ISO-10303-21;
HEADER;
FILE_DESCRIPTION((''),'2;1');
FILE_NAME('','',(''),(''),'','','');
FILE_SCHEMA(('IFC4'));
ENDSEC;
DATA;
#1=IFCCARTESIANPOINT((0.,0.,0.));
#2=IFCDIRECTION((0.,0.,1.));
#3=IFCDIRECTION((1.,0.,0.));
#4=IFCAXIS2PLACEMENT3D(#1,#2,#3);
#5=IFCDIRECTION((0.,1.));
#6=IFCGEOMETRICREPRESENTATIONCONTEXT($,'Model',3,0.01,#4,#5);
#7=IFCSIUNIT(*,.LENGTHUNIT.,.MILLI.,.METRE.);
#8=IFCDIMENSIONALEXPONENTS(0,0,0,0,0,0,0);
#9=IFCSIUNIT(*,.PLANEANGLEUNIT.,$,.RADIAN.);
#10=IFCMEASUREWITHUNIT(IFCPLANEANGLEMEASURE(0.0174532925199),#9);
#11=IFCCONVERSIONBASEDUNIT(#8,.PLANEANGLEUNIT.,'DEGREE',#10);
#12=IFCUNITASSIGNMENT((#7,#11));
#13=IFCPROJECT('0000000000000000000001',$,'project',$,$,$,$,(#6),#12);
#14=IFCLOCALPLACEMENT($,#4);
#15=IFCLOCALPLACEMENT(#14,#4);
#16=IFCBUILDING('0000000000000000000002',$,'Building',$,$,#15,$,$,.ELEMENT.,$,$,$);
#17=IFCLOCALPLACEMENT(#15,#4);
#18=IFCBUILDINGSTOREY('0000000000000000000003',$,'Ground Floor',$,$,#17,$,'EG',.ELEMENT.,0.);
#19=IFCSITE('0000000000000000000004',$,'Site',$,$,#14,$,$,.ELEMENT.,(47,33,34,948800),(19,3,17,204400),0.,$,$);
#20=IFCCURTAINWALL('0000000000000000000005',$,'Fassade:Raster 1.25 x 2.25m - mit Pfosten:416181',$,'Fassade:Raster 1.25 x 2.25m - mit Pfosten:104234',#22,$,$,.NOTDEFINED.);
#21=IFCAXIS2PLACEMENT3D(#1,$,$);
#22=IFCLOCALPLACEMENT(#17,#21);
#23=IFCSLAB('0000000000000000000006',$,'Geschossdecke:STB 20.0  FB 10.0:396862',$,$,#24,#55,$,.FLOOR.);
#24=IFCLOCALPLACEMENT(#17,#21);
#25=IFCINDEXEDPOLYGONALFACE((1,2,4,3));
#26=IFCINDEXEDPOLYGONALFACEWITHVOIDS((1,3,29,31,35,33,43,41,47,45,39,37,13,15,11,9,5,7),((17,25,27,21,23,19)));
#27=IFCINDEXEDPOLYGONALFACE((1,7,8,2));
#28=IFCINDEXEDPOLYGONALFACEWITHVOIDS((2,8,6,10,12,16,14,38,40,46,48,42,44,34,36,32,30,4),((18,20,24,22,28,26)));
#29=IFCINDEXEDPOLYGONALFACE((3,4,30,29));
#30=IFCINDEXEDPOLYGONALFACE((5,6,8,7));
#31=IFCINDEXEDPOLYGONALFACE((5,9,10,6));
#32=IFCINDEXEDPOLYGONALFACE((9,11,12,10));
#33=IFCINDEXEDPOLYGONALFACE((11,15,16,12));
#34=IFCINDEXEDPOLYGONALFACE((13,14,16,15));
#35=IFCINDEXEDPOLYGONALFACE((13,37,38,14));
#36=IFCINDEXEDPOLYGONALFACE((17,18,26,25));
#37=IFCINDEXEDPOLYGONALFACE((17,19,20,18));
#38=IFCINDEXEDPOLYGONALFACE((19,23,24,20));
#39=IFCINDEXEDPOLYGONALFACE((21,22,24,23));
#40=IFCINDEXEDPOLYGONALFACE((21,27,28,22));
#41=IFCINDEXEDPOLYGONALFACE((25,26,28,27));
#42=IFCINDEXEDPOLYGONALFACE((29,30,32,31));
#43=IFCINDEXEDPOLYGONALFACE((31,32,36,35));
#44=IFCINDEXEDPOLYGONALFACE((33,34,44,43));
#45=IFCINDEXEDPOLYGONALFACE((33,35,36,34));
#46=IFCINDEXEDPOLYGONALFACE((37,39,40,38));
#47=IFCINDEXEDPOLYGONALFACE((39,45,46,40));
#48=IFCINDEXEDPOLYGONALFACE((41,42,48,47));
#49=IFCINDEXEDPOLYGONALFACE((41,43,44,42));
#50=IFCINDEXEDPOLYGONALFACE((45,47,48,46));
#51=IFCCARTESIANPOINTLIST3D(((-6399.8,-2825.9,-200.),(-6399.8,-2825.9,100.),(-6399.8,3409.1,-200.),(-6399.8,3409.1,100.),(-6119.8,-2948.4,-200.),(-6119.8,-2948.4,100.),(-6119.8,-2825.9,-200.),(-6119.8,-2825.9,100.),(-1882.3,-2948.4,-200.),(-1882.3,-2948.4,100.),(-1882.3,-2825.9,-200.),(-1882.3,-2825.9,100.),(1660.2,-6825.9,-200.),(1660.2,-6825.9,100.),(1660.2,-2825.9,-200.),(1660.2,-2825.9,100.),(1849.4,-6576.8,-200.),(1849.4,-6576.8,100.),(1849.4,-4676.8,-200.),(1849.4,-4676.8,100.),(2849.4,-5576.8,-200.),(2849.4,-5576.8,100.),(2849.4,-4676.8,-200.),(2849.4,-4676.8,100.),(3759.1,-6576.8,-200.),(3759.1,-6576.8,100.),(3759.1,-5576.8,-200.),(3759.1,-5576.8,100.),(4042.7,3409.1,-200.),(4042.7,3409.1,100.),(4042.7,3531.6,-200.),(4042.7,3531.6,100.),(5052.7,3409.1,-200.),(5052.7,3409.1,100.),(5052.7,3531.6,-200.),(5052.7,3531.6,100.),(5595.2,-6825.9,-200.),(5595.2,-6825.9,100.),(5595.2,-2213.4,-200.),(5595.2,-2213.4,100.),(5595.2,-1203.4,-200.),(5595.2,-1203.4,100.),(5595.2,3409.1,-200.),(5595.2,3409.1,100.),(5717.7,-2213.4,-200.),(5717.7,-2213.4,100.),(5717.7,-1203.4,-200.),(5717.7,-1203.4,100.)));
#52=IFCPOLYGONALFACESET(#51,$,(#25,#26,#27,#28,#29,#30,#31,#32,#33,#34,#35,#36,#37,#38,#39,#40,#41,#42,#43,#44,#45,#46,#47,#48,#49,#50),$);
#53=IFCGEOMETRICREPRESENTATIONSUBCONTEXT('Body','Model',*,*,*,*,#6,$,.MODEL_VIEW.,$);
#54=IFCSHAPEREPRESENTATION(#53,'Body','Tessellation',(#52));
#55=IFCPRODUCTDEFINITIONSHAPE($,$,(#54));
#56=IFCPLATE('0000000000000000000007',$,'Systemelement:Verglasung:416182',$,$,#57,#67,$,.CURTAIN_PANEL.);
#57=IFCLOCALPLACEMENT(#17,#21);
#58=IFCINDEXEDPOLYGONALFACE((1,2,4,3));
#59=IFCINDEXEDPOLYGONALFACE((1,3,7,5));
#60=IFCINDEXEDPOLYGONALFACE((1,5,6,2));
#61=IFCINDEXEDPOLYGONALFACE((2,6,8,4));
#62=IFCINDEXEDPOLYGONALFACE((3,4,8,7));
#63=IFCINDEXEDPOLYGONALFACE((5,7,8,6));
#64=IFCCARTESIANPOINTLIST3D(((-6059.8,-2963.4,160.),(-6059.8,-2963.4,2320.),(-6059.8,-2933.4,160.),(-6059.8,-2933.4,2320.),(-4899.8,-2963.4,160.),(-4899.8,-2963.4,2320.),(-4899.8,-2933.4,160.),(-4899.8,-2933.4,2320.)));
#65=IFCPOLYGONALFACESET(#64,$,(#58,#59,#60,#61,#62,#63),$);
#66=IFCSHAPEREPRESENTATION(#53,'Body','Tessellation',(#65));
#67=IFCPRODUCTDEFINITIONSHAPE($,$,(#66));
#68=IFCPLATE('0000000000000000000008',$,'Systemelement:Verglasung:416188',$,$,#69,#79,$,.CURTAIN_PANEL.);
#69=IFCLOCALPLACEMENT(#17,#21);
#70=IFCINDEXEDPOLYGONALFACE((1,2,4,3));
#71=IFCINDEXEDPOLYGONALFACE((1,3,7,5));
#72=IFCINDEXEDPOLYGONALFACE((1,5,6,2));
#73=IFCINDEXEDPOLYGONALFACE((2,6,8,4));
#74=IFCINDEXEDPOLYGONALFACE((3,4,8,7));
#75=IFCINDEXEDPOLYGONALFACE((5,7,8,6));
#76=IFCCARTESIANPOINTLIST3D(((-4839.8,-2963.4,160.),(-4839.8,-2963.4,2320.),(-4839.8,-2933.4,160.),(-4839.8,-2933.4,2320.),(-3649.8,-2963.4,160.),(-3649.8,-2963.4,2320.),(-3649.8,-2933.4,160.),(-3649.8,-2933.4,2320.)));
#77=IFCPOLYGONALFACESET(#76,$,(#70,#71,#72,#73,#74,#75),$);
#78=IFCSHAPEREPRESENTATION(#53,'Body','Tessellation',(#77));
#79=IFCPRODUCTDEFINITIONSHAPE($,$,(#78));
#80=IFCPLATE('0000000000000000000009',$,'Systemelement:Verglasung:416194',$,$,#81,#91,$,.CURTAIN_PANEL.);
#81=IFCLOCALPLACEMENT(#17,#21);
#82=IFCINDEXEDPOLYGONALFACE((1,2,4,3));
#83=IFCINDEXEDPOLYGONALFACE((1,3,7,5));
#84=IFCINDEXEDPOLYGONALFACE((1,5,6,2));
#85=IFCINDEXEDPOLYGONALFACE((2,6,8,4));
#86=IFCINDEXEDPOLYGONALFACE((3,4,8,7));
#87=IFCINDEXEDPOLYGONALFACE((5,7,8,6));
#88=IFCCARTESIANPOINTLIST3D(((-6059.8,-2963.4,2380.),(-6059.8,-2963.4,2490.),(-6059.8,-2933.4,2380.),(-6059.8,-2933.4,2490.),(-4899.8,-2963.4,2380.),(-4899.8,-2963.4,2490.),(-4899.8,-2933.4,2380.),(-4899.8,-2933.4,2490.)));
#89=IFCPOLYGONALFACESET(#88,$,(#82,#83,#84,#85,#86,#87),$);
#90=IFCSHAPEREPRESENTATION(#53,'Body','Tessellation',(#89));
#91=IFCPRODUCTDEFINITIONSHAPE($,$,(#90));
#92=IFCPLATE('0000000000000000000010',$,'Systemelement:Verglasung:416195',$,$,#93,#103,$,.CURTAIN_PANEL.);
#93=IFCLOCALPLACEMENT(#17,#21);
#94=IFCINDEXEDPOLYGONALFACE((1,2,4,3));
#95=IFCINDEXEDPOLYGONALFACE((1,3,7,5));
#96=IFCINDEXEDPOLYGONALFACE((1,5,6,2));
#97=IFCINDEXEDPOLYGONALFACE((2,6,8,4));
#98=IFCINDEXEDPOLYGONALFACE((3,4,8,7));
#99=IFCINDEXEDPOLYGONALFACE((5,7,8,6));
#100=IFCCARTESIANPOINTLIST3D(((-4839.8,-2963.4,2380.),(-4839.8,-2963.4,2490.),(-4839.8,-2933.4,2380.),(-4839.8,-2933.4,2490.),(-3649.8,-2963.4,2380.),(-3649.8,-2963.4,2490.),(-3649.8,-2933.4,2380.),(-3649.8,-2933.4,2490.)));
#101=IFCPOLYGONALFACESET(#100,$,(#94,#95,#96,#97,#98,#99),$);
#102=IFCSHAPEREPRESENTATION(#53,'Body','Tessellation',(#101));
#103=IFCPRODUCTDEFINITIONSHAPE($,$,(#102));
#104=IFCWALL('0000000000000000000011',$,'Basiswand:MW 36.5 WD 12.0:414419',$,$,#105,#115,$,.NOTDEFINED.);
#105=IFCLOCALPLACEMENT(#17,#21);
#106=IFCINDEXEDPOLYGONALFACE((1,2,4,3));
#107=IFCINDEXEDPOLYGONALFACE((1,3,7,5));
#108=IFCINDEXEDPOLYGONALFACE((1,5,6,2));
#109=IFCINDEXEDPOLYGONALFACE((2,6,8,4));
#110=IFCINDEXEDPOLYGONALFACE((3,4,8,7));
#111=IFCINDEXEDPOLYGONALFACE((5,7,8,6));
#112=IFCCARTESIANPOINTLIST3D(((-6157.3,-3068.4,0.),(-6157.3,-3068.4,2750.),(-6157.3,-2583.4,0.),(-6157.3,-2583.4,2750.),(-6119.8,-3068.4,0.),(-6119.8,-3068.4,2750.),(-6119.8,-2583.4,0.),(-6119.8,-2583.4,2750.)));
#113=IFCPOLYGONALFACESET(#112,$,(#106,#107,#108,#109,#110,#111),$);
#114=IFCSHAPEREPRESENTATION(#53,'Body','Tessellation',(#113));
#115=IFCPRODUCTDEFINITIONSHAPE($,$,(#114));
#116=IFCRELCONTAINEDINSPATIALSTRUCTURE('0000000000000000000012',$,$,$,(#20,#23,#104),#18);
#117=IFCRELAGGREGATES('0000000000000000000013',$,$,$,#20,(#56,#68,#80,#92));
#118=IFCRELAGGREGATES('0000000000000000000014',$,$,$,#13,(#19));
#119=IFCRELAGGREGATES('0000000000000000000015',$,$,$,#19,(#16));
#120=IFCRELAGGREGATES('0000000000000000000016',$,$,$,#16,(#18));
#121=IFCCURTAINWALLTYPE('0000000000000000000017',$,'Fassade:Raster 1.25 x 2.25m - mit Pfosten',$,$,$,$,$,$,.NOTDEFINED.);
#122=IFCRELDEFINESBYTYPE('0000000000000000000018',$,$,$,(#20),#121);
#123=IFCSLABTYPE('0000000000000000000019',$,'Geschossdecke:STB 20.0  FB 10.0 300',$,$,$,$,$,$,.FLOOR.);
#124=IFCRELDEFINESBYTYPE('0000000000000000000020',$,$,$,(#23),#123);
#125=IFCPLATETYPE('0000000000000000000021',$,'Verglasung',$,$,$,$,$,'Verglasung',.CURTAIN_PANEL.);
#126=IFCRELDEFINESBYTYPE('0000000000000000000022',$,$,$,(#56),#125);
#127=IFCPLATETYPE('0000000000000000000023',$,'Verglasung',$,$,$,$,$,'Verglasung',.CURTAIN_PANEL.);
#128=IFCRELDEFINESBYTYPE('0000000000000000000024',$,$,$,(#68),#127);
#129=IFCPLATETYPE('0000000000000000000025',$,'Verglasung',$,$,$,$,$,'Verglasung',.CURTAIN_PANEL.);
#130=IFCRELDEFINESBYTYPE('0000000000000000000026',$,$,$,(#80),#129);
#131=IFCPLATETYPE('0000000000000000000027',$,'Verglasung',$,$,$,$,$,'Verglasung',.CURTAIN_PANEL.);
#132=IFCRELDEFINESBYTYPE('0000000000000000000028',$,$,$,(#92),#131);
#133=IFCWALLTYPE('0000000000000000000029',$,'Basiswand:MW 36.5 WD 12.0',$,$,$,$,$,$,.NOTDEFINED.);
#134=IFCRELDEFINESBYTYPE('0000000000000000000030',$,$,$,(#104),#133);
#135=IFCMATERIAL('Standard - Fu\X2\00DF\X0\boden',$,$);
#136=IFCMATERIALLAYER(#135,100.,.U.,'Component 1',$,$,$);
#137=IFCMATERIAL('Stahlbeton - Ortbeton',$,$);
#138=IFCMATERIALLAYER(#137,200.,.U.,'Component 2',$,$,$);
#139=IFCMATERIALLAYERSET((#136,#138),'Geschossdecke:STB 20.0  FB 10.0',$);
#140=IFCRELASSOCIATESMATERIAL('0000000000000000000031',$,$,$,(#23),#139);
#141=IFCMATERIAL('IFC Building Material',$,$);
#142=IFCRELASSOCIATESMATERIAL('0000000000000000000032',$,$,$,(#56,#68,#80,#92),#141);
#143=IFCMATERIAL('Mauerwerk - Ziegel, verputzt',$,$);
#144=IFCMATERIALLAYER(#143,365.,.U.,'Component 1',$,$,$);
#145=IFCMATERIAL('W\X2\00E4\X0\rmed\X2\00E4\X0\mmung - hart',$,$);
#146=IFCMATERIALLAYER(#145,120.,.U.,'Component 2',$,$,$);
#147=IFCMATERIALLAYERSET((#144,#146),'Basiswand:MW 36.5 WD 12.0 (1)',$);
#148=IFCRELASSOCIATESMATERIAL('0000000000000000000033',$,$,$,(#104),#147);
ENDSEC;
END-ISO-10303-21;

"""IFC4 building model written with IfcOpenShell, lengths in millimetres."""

from ifc_helpers import new_model, entity, si_unit, converted_unit, direction, frame, origin_with_axes, origin_2d_with_axis, place, context, subcontext, project, spatial, line, indexed_curve, rectangle, outline, extrude, material, layer, layer_set, layer_usage, type_object, element, aggregate, save


model = new_model("IFC4")

# Units and contexts
model_context = context("Model", 3, precision=0.01, world=origin_with_axes(), true_north=direction((0.0, 1.0)))
body_context = subcontext(model_context, "Body", "Model", "MODEL_VIEW")
ifc_project = project(units=[si_unit("LENGTHUNIT", "METRE", prefix="MILLI"), converted_unit("PLANEANGLEUNIT", "DEGREE", entity("IfcPlaneAngleMeasure", 0.0174532925199), si_unit("PLANEANGLEUNIT", "RADIAN"), dimensions=[0, 0, 0, 0, 0, 0, 0])], contexts=[model_context])

# Site, building, storey
site_placement = place(None, origin_with_axes())
site = spatial("IfcSite", under=ifc_project, at=site_placement, Name="Site", CompositionType="ELEMENT", RefLatitude=(47, 33, 34, 948800), RefLongitude=(19, 3, 17, 204400), RefElevation=0.0)
building_placement = place(site_placement, origin_with_axes())
building = spatial("IfcBuilding", under=site, at=building_placement, Name="Building", CompositionType="ELEMENT")
storey_placement = place(building_placement, origin_with_axes())
storey = spatial("IfcBuildingStorey", under=building, at=storey_placement, Name="Ground Floor", LongName="EG", CompositionType="ELEMENT", Elevation=0.0)

# Curtain wall
curtain_wall_type = type_object("IfcCurtainWallType", Name="Fassade:Raster 1.25 x 2.25m - mit Pfosten", PredefinedType="NOTDEFINED")
curtain_wall_placement = place(storey_placement, origin_with_axes())
curtain_wall = element("IfcCurtainWall", 1, at=curtain_wall_placement, inside=storey, type_object=curtain_wall_type, Name="Fassade:Raster 1.25 x 2.25m - mit Pfosten:416181", ObjectType="Fassade:Raster 1.25 x 2.25m - mit Pfosten:104234", PredefinedType="NOTDEFINED")

# Slab, opening
ifc_material_1 = material(Name="Standard - Fußboden")
ifc_layer_1 = layer(ifc_material_1, 100.0, ventilated="UNKNOWN", Name="Component 1")
ifc_material_2 = material(Name="Stahlbeton - Ortbeton")
ifc_layer_2 = layer(ifc_material_2, 200.0, ventilated="UNKNOWN", Name="Component 2")
ifc_layer_set_1 = layer_set([ifc_layer_1, ifc_layer_2], Name="Geschossdecke:STB 20.0  FB 10.0")
ifc_layer_usage_1 = layer_usage(ifc_layer_set_1, "AXIS3", "NEGATIVE", 300.0)
slab_type = type_object("IfcSlabType", Name="Geschossdecke:STB 20.0  FB 10.0 300", PredefinedType="FLOOR")
slab_placement = place(storey_placement, frame((-6399.8, 3409.1, 100.0), z_axis=(0.0, 0.0, 1.0), x_axis=(1.0, 0.0, 0.0)))
slab = element("IfcSlab", 2, at=slab_placement, inside=storey, type_object=slab_type, material=ifc_layer_usage_1, Name="Geschossdecke:STB 20.0  FB 10.0:396862", PredefinedType="FLOOR", context=body_context, shape_type="SweptSolid", body=[
    extrude(outline(indexed_curve([(0.0, 0.0), (0.0, -6235.0), (280.0, -6235.0), (280.0, -6357.5), (4517.5, -6357.5), (4517.5, -6235.0), (8060.0, -6235.0), (8060.0, -10235.0), (11995.0, -10235.0), (11995.0, -5622.5), (12117.5, -5622.5), (12117.5, -4612.5), (11995.0, -4612.5), (11995.0, 0.0), (11452.5, 0.0), (11452.5, 122.5), (10442.5, 122.5), (10442.5, 0.0)], segments=[line(1, 2, 3, 4, 5, 6, 7, 8, 9, 10, 11, 12, 13, 14, 15, 16, 17, 18, 1)])), frame((0.0, 0.0, -300.0), z_axis=(0.0, 0.0, 1.0), x_axis=(1.0, 0.0, 0.0)), (0.0, 0.0, 1.0), 300.0),
])
opening_placement = place(slab_placement, frame((8249.2, -8085.8, 0.0), z_axis=(0.0, 0.0, 1.0), x_axis=(0.0, -1.0, 0.0)))
element("IfcOpeningElement", 3, at=opening_placement, cuts=slab, context=body_context, shape_type="SweptSolid", body=[
    extrude(outline(indexed_curve([(0.0, 0.0), (1900.0, 0.0), (1900.0, 1909.7), (900.0, 1909.7), (900.0, 1000.0), (0.0, 1000.0)], segments=[line(1, 2, 3, 4, 5, 6, 1)])), frame((0.0, 0.0, -300.0), z_axis=(0.0, 0.0, 1.0), x_axis=(1.0, 0.0, 0.0)), (0.0, 0.0, 1.0), 300.0),
])

# Plates
ifc_material_3 = material(Name="IFC Building Material")
plate_type_1 = type_object("IfcPlateType", Name="Verglasung", ElementType="Verglasung", PredefinedType="CURTAIN_PANEL")
plate_1_placement = place(curtain_wall_placement, frame((-5479.8, -2948.4, 160.0), z_axis=(0.0, 0.0, 1.0), x_axis=(1.0, 0.0, 0.0)))
plate_1 = element("IfcPlate", 4, at=plate_1_placement, type_object=plate_type_1, material=ifc_material_3, Name="Systemelement:Verglasung:416182", PredefinedType="CURTAIN_PANEL", context=body_context, shape_type="SweptSolid", body=[
    extrude(rectangle(XDim=30.0, YDim=1160.0, at=origin_2d_with_axis()), frame((0.0, 0.0, 0.0), z_axis=(0.0, 0.0, 1.0), x_axis=(0.0, 1.0, 0.0)), (0.0, 0.0, 1.0), 2160.0),
])
plate_type_2 = type_object("IfcPlateType", Name="Verglasung", ElementType="Verglasung", PredefinedType="CURTAIN_PANEL")
plate_2_placement = place(curtain_wall_placement, frame((-4244.8, -2948.4, 160.0), z_axis=(0.0, 0.0, 1.0), x_axis=(1.0, 0.0, 0.0)))
plate_2 = element("IfcPlate", 5, at=plate_2_placement, type_object=plate_type_2, material=ifc_material_3, Name="Systemelement:Verglasung:416188", PredefinedType="CURTAIN_PANEL", context=body_context, shape_type="SweptSolid", body=[
    extrude(rectangle(XDim=30.0, YDim=1190.0, at=origin_2d_with_axis()), frame((0.0, 0.0, 0.0), z_axis=(0.0, 0.0, 1.0), x_axis=(0.0, 1.0, 0.0)), (0.0, 0.0, 1.0), 2160.0),
])
plate_type_3 = type_object("IfcPlateType", Name="Verglasung", ElementType="Verglasung", PredefinedType="CURTAIN_PANEL")
plate_3_placement = place(curtain_wall_placement, frame((-5479.8, -2948.4, 2380.0), z_axis=(0.0, 0.0, 1.0), x_axis=(1.0, 0.0, 0.0)))
plate_3 = element("IfcPlate", 6, at=plate_3_placement, type_object=plate_type_3, material=ifc_material_3, Name="Systemelement:Verglasung:416194", PredefinedType="CURTAIN_PANEL", context=body_context, shape_type="SweptSolid", body=[
    extrude(rectangle(XDim=30.0, YDim=1160.0, at=origin_2d_with_axis()), frame((0.0, 0.0, 0.0), z_axis=(0.0, 0.0, 1.0), x_axis=(0.0, 1.0, 0.0)), (0.0, 0.0, 1.0), 110.0),
])
plate_type_4 = type_object("IfcPlateType", Name="Verglasung", ElementType="Verglasung", PredefinedType="CURTAIN_PANEL")
plate_4_placement = place(curtain_wall_placement, frame((-4244.8, -2948.4, 2380.0), z_axis=(0.0, 0.0, 1.0), x_axis=(1.0, 0.0, 0.0)))
plate_4 = element("IfcPlate", 7, at=plate_4_placement, type_object=plate_type_4, material=ifc_material_3, Name="Systemelement:Verglasung:416195", PredefinedType="CURTAIN_PANEL", context=body_context, shape_type="SweptSolid", body=[
    extrude(rectangle(XDim=30.0, YDim=1190.0, at=origin_2d_with_axis()), frame((0.0, 0.0, 0.0), z_axis=(0.0, 0.0, 1.0), x_axis=(0.0, 1.0, 0.0)), (0.0, 0.0, 1.0), 110.0),
])
aggregate(curtain_wall, [plate_1, plate_2, plate_3, plate_4])

# Wall
ifc_material_4 = material(Name="Mauerwerk - Ziegel, verputzt")
ifc_layer_3 = layer(ifc_material_4, 365.0, ventilated="UNKNOWN", Name="Component 1")
ifc_material_5 = material(Name="Wärmedämmung - hart")
ifc_layer_4 = layer(ifc_material_5, 120.0, ventilated="UNKNOWN", Name="Component 2")
ifc_layer_set_2 = layer_set([ifc_layer_3, ifc_layer_4], Name="Basiswand:MW 36.5 WD 12.0 (1)")
ifc_layer_usage_2 = layer_usage(ifc_layer_set_2, "AXIS2", "POSITIVE", -242.5)
wall_type = type_object("IfcWallType", Name="Basiswand:MW 36.5 WD 12.0", PredefinedType="NOTDEFINED")
wall_placement = place(storey_placement, frame((-6119.8, -2825.9, 0.0), z_axis=(0.0, 0.0, 1.0), x_axis=(-1.0, 0.0, 0.0)))
element("IfcWall", 8, at=wall_placement, inside=storey, type_object=wall_type, material=ifc_layer_usage_2, Name="Basiswand:MW 36.5 WD 12.0:414419", PredefinedType="NOTDEFINED", context=body_context, shape_type="SweptSolid", body=[
    extrude(outline(indexed_curve([(0.0, -242.5), (37.5, -242.5), (37.5, 242.5), (0.0, 242.5)], segments=[line(1, 2, 3, 4, 1)])), origin_with_axes(), (0.0, 0.0, 1.0), 2750.0),
])

save(model, "model.ifc")
